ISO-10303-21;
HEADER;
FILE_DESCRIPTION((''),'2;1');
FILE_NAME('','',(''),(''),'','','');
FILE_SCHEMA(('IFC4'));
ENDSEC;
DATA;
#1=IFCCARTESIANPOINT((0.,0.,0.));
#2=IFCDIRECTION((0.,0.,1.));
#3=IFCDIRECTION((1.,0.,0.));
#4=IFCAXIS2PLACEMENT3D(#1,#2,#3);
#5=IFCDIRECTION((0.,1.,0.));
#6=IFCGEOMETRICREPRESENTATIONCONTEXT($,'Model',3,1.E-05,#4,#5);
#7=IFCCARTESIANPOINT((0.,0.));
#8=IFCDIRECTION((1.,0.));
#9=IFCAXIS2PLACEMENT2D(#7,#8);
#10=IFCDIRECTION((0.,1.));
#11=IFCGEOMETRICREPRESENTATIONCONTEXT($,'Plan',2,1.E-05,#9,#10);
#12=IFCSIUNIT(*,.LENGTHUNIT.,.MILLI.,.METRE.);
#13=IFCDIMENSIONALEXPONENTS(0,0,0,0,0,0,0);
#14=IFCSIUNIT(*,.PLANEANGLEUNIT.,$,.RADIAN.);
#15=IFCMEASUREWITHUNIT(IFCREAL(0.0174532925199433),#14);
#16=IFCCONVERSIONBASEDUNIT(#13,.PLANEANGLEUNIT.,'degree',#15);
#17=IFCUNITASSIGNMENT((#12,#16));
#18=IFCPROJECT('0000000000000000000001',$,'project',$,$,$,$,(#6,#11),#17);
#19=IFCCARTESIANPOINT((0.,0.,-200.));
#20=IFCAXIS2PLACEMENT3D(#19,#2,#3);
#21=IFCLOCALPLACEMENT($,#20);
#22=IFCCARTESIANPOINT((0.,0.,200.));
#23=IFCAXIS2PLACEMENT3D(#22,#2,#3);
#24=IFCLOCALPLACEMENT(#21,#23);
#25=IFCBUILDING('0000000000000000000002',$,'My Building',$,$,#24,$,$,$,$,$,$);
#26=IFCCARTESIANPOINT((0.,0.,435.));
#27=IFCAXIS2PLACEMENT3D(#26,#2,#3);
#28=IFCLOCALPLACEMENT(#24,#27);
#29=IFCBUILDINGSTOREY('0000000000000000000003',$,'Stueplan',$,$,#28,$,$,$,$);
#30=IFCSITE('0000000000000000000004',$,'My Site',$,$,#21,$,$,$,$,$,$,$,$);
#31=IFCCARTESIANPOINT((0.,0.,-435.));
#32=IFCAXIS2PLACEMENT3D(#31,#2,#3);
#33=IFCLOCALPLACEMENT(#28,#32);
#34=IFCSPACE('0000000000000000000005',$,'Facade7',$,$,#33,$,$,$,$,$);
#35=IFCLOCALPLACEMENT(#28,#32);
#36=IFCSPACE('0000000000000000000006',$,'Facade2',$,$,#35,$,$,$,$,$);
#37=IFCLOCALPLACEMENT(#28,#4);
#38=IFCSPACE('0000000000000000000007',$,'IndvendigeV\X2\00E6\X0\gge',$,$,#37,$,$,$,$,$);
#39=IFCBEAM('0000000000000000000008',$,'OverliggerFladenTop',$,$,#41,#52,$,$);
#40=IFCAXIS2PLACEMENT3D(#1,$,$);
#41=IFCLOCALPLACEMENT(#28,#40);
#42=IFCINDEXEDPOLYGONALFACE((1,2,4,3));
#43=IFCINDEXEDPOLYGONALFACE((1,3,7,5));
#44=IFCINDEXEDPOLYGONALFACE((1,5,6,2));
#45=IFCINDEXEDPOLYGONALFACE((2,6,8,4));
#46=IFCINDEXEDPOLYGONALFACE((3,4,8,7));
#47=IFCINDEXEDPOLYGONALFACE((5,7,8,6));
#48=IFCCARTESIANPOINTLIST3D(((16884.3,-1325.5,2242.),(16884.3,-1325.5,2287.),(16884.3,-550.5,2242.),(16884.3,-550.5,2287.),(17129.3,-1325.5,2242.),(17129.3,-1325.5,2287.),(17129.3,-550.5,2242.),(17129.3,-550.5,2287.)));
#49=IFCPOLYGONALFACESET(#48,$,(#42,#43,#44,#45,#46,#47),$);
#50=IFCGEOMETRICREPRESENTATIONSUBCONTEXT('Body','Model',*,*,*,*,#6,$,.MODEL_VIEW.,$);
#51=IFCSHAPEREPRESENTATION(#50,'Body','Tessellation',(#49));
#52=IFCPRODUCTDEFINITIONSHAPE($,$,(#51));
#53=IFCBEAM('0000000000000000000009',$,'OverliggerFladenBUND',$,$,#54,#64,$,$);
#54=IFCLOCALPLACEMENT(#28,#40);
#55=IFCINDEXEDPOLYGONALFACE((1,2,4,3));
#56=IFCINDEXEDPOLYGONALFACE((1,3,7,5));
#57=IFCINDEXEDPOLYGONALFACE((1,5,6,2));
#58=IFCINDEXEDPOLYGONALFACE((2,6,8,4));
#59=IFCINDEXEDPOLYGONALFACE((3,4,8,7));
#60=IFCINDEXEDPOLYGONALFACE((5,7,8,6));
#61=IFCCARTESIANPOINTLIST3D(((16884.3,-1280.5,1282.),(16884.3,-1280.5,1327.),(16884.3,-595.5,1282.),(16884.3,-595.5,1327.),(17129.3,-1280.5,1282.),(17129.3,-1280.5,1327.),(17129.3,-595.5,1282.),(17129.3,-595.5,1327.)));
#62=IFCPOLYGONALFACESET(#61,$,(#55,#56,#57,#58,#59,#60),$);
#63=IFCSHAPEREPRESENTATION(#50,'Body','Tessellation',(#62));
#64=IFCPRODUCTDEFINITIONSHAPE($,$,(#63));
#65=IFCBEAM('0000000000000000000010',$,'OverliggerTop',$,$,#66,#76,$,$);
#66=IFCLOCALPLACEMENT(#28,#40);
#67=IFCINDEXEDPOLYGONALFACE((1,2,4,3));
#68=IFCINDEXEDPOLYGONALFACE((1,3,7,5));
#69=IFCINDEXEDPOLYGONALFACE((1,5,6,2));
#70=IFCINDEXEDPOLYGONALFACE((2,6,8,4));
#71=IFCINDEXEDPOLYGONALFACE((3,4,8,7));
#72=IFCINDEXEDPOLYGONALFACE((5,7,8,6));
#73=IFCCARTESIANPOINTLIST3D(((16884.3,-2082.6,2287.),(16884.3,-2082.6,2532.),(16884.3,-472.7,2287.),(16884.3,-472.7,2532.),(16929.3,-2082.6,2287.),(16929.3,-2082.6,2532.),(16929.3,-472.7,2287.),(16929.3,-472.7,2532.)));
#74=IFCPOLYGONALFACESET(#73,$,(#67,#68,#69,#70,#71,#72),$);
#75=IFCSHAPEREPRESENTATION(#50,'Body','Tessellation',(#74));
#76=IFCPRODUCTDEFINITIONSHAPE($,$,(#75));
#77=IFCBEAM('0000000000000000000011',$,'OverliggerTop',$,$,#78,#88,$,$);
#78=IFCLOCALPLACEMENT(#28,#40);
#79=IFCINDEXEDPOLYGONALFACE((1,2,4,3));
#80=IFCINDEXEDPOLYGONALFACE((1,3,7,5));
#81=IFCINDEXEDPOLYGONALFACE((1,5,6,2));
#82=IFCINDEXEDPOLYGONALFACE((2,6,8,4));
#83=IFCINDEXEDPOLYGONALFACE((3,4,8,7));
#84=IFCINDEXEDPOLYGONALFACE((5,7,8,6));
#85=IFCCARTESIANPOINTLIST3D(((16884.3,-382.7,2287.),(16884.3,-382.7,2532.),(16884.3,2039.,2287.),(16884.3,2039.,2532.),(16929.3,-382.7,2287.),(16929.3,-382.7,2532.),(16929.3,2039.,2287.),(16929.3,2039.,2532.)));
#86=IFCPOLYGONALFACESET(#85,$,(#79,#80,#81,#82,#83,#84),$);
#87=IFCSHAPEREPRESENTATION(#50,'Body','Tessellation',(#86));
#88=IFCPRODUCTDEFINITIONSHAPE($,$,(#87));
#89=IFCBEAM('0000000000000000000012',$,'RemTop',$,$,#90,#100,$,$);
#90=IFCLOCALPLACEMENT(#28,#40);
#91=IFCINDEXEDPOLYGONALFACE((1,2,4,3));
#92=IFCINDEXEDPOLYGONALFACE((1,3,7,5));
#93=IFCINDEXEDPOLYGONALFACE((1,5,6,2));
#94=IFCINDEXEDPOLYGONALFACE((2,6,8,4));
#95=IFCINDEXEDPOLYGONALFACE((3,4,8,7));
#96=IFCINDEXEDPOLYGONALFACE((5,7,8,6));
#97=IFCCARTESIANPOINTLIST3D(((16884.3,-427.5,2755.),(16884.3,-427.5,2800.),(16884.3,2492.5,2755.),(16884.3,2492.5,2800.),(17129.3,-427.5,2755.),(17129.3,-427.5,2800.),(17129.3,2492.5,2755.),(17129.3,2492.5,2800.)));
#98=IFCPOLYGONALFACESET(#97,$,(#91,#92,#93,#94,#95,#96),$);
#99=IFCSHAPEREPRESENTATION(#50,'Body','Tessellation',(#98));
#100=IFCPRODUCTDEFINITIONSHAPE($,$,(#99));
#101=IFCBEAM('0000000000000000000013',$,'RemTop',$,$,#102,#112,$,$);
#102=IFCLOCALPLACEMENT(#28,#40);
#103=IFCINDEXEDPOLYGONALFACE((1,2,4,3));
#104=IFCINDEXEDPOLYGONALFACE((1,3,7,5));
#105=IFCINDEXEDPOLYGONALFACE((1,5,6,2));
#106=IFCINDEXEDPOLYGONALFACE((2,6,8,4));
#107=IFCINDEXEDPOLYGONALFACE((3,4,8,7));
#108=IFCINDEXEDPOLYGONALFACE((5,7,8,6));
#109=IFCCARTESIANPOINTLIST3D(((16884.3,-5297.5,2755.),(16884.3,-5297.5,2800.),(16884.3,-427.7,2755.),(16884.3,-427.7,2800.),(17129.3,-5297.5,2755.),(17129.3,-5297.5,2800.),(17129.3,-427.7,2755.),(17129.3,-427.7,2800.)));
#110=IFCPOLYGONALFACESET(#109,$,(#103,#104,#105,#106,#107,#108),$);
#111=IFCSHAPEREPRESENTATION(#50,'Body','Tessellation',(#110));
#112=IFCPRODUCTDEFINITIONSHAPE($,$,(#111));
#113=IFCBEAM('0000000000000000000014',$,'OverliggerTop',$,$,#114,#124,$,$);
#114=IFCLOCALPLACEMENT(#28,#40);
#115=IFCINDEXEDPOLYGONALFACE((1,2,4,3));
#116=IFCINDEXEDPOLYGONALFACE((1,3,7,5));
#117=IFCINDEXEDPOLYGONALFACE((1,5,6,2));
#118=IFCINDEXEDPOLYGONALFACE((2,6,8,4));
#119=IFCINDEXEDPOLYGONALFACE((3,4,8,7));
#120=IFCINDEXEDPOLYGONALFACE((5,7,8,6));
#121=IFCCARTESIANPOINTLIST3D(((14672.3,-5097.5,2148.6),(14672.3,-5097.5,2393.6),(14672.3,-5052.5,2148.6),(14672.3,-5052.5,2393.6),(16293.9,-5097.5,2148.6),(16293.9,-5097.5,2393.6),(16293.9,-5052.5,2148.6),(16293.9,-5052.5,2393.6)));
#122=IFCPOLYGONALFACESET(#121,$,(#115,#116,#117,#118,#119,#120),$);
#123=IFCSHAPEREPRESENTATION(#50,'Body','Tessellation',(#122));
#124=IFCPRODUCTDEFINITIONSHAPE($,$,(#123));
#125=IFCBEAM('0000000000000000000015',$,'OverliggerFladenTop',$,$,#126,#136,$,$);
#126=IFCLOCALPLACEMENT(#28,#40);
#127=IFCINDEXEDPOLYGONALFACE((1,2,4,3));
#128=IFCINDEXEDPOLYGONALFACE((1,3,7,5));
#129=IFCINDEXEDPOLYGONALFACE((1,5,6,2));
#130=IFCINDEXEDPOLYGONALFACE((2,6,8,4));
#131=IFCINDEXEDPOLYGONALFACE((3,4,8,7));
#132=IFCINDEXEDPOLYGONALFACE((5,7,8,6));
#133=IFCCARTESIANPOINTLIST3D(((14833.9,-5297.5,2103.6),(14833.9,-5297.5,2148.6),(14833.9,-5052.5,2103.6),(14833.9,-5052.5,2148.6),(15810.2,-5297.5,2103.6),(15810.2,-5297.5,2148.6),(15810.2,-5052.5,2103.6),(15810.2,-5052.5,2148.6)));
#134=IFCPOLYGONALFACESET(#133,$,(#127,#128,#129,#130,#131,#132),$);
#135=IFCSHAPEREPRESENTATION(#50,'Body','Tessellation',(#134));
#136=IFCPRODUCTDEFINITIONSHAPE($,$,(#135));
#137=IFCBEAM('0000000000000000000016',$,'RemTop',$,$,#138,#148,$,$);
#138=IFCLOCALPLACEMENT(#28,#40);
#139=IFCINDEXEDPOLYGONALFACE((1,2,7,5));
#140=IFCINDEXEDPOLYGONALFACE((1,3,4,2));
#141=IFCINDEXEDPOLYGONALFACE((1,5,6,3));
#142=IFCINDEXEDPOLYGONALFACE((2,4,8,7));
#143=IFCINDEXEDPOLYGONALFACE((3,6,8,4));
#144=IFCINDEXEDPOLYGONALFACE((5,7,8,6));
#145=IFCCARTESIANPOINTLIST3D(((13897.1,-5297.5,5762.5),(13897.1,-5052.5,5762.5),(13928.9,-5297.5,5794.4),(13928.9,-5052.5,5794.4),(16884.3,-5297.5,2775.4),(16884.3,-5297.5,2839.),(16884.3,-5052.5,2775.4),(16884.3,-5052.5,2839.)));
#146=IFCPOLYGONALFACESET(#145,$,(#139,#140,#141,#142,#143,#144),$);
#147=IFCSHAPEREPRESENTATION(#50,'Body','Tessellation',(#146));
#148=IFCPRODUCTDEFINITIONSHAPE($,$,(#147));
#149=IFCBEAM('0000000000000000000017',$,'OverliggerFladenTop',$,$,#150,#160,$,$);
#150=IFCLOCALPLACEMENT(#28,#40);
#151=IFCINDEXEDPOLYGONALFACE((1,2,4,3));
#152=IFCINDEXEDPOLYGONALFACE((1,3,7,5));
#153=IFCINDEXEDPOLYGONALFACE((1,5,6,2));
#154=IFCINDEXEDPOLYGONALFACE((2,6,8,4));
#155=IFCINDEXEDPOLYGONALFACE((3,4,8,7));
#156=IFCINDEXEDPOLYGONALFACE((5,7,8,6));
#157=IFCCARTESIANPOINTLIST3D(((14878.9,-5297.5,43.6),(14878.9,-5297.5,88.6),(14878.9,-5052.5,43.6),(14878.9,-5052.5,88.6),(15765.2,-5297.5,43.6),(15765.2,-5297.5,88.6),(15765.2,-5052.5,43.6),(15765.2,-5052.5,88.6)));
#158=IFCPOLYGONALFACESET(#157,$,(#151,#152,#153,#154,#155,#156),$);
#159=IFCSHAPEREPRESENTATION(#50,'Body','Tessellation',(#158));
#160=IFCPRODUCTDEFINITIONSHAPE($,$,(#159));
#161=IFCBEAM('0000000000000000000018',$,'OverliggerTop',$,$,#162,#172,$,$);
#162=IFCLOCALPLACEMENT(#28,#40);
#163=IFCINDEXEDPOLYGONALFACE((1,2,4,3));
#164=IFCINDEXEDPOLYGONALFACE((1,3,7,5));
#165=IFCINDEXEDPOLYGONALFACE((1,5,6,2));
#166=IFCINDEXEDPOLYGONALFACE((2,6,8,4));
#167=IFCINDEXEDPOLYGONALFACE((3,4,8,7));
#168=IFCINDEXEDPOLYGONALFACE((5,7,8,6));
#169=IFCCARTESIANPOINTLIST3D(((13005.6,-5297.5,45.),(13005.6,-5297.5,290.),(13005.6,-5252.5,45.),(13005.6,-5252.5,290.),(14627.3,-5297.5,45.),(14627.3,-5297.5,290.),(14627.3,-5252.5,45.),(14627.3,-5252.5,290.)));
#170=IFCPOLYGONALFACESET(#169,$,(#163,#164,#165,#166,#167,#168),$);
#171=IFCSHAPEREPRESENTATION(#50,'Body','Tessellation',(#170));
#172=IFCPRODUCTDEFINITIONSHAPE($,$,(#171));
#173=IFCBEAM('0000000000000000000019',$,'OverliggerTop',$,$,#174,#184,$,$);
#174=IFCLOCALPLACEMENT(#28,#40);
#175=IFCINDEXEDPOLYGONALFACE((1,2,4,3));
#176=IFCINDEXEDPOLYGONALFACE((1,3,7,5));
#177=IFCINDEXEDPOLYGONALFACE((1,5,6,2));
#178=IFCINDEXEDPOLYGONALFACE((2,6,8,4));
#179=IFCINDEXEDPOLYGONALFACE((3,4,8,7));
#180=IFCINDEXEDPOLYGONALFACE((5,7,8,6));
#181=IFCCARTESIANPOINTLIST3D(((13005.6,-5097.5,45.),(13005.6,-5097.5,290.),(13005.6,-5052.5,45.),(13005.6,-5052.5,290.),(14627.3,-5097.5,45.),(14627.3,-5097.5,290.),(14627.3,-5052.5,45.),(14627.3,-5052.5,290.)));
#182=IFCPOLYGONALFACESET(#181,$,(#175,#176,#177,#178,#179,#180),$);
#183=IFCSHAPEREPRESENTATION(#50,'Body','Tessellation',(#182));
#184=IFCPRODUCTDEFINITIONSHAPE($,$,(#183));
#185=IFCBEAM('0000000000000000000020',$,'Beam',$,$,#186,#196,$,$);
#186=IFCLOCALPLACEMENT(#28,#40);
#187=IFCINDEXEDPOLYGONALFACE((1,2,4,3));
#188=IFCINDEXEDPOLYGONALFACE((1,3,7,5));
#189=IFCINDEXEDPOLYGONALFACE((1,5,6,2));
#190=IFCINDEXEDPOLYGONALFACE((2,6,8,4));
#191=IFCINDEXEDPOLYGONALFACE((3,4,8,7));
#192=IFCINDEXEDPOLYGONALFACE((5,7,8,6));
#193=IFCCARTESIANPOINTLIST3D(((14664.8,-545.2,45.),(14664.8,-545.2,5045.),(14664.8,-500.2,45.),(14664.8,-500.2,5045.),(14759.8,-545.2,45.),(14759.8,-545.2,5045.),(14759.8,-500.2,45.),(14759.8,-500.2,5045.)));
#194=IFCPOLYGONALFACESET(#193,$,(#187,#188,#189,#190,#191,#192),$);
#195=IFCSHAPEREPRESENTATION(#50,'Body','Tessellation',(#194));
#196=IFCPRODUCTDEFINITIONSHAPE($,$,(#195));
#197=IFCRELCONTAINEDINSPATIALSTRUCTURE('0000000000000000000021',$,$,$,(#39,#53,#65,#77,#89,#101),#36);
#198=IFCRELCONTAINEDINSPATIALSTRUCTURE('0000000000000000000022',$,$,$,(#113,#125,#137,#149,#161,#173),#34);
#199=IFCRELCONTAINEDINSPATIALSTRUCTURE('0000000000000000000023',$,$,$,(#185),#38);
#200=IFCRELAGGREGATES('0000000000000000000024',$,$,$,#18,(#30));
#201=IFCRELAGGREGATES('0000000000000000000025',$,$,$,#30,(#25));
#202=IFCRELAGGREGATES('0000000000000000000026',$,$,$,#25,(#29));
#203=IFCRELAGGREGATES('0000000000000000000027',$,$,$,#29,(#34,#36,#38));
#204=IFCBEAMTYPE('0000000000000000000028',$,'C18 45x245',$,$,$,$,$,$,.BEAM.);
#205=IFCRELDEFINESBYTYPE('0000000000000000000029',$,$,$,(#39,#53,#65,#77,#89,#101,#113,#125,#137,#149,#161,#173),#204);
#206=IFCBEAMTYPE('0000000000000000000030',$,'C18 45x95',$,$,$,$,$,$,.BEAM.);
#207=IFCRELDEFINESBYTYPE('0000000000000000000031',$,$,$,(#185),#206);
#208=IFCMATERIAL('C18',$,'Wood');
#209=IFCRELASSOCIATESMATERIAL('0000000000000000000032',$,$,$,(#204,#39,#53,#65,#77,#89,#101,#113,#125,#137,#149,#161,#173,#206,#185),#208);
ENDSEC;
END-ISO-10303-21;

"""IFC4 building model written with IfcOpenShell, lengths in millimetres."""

from ifc_helpers import new_model, entity, si_unit, converted_unit, direction, frame, origin_with_axes, origin_2d_with_axis, place, context, subcontext, project, spatial, rectangle, extrude, clip, halfspace, material, material_profile, profile_set, profile_usage, type_object, element, save


model = new_model("IFC4")

# Units and contexts
model_context = context("Model", 3, precision=1e-05, world=origin_with_axes(), true_north=direction((0.0, 1.0, 0.0)))
plan_context = context("Plan", 2, precision=1e-05, world=origin_2d_with_axis(), true_north=direction((0.0, 1.0)))
body_context_1 = subcontext(model_context, "Body", "Model", "MODEL_VIEW")
ifc_project = project(units=[si_unit("LENGTHUNIT", "METRE", prefix="MILLI"), converted_unit("PLANEANGLEUNIT", "degree", entity("IfcReal", 0.0174532925199433), si_unit("PLANEANGLEUNIT", "RADIAN"), dimensions=[0, 0, 0, 0, 0, 0, 0])], contexts=[model_context, plan_context])

# Site, building, storey, space
site_placement = place(None, frame((0.0, 0.0, -200.0), z_axis=(0.0, 0.0, 1.0), x_axis=(1.0, 0.0, 0.0)))
site = spatial("IfcSite", under=ifc_project, at=site_placement, Name="My Site")
building_placement = place(site_placement, frame((0.0, 0.0, 200.0), z_axis=(0.0, 0.0, 1.0), x_axis=(1.0, 0.0, 0.0)))
building = spatial("IfcBuilding", under=site, at=building_placement, Name="My Building")
storey_placement = place(building_placement, frame((0.0, 0.0, 435.0), z_axis=(0.0, 0.0, 1.0), x_axis=(1.0, 0.0, 0.0)))
storey = spatial("IfcBuildingStorey", under=building, at=storey_placement, Name="Stueplan")
space_1_placement = place(storey_placement, frame((0.0, 0.0, -435.0), z_axis=(0.0, 0.0, 1.0), x_axis=(1.0, 0.0, 0.0)))
space_1 = spatial("IfcSpace", under=storey, at=space_1_placement, Name="Facade7")

# Shared definitions
ifc_material = material(Name="C18", Category="Wood")

# Shared definitions
space_2_placement = place(storey_placement, frame((0.0, 0.0, -435.0), z_axis=(0.0, 0.0, 1.0), x_axis=(1.0, 0.0, 0.0)))
space_2 = spatial("IfcSpace", under=storey, at=space_2_placement, Name="Facade2")

# Beams
ifc_material_profile_1 = material_profile(ifc_material, rectangle(XDim=45.0, YDim=245.0), Name="concrete")
ifc_profile_set_1 = profile_set([ifc_material_profile_1], Name="woodStructural")
ifc_profile_usage_1 = profile_usage(ifc_profile_set_1)
beam_type_1 = type_object("IfcBeamType", Name="C18 45x245", PredefinedType="BEAM", material=ifc_profile_set_1)
beam_1_placement = place(space_2_placement, frame((17006.8, -1325.5, 2699.5), z_axis=(0.0, 1.0, 0.0), x_axis=(0.0, 0.0, 1.0)))
element("IfcBeam", 1, at=beam_1_placement, inside=space_2, type_object=beam_type_1, material=ifc_profile_usage_1, Name="OverliggerFladenTop", context=body_context_1, shape_type="SweptSolid", body=[
    extrude(rectangle(XDim=45.0, YDim=245.0), origin_with_axes(), (0.0, 0.0, 1.0), 775.0),
])
ifc_profile_usage_2 = profile_usage(ifc_profile_set_1)
beam_2_placement = place(space_2_placement, frame((17006.8, -1280.5, 1739.5), z_axis=(0.0, 1.0, 0.0), x_axis=(0.0, 0.0, 1.0)))
element("IfcBeam", 2, at=beam_2_placement, inside=space_2, type_object=beam_type_1, material=ifc_profile_usage_2, Name="OverliggerFladenBUND", context=body_context_1, shape_type="SweptSolid", body=[
    extrude(rectangle(XDim=45.0, YDim=245.0), origin_with_axes(), (0.0, 0.0, 1.0), 685.0),
])
ifc_profile_usage_3 = profile_usage(ifc_profile_set_1)
beam_3_placement = place(space_2_placement, frame((16906.8, -2082.6, 2844.5), z_axis=(0.0, 1.0, 0.0), x_axis=(1.0, 0.0, 0.0)))
element("IfcBeam", 3, at=beam_3_placement, inside=space_2, type_object=beam_type_1, material=ifc_profile_usage_3, Name="OverliggerTop", context=body_context_1, shape_type="SweptSolid", body=[
    extrude(rectangle(XDim=45.0, YDim=245.0), origin_with_axes(), (0.0, 0.0, 1.0), 1609.9),
])
ifc_profile_usage_4 = profile_usage(ifc_profile_set_1)
beam_4_placement = place(space_2_placement, frame((16906.8, -382.7, 2844.5), z_axis=(0.0, 1.0, 0.0), x_axis=(1.0, 0.0, 0.0)))
element("IfcBeam", 4, at=beam_4_placement, inside=space_2, type_object=beam_type_1, material=ifc_profile_usage_4, Name="OverliggerTop", context=body_context_1, shape_type="SweptSolid", body=[
    extrude(rectangle(XDim=45.0, YDim=245.0), origin_with_axes(), (0.0, 0.0, 1.0), 2421.7),
])
ifc_profile_usage_5 = profile_usage(ifc_profile_set_1)
beam_5_placement = place(space_2_placement, frame((17006.8, -427.5, 3212.5), z_axis=(0.0, 1.0, 0.0), x_axis=(0.0, 0.0, 1.0)))
element("IfcBeam", 5, at=beam_5_placement, inside=space_2, type_object=beam_type_1, material=ifc_profile_usage_5, Name="RemTop", context=body_context_1, shape_type="SweptSolid", body=[
    extrude(rectangle(XDim=45.0, YDim=245.0), origin_with_axes(), (0.0, 0.0, 1.0), 2920.0),
])
ifc_profile_usage_6 = profile_usage(ifc_profile_set_1)
beam_6_placement = place(space_2_placement, frame((17006.8, -5297.5, 3212.5), z_axis=(0.0, 1.0, 0.0), x_axis=(0.0, 0.0, 1.0)))
element("IfcBeam", 6, at=beam_6_placement, inside=space_2, type_object=beam_type_1, material=ifc_profile_usage_6, Name="RemTop", context=body_context_1, shape_type="SweptSolid", body=[
    extrude(rectangle(XDim=45.0, YDim=245.0), origin_with_axes(), (0.0, 0.0, 1.0), 4869.8),
])
ifc_profile_usage_7 = profile_usage(ifc_profile_set_1)
beam_7_placement = place(space_1_placement, frame((14672.3, -5075.0, 2706.1), z_axis=(1.0, 0.0, 0.0), x_axis=(0.0, -1.0, 0.0)))
element("IfcBeam", 7, at=beam_7_placement, inside=space_1, type_object=beam_type_1, material=ifc_profile_usage_7, Name="OverliggerTop", context=body_context_1, shape_type="SweptSolid", body=[
    extrude(rectangle(XDim=45.0, YDim=245.0), origin_with_axes(), (0.0, 0.0, 1.0), 1621.7),
])
ifc_profile_usage_8 = profile_usage(ifc_profile_set_1)
beam_8_placement = place(space_1_placement, frame((14833.9, -5175.0, 2561.1), z_axis=(1.0, 0.0, 0.0), x_axis=(0.0, 0.0, 1.0)))
element("IfcBeam", 8, at=beam_8_placement, inside=space_1, type_object=beam_type_1, material=ifc_profile_usage_8, Name="OverliggerFladenTop", context=body_context_1, shape_type="SweptSolid", body=[
    extrude(rectangle(XDim=45.0, YDim=245.0), origin_with_axes(), (0.0, 0.0, 1.0), 976.4),
])
ifc_profile_usage_9 = profile_usage(ifc_profile_set_1)
beam_9_placement = place(space_1_placement, frame((13913.0, -5175.0, 6213.4), z_axis=(0.707107, 0.0, -0.707107), x_axis=(0.707107, 0.000001, 0.707107)))
element("IfcBeam", 9, at=beam_9_placement, inside=space_1, type_object=beam_type_1, material=ifc_profile_usage_9, Name="RemTop", context=body_context_1, shape_type="Clipping", body=[
    clip(extrude(rectangle(XDim=45.0, YDim=245.0), origin_with_axes(), (0.0, 0.0, 1.0), 4447.0), halfspace(frame((-1953.2, 122.5, 6155.1), z_axis=(0.707107, 0.000001, 0.707107), x_axis=(0.000001, -1.0, 0.0)), False)),
])
ifc_profile_usage_10 = profile_usage(ifc_profile_set_1)
beam_10_placement = place(space_1_placement, frame((14878.9, -5175.0, 501.1), z_axis=(1.0, 0.0, 0.0), x_axis=(0.0, 0.0, 1.0)))
element("IfcBeam", 10, at=beam_10_placement, inside=space_1, type_object=beam_type_1, material=ifc_profile_usage_10, Name="OverliggerFladenTop", context=body_context_1, shape_type="SweptSolid", body=[
    extrude(rectangle(XDim=45.0, YDim=245.0), origin_with_axes(), (0.0, 0.0, 1.0), 886.4),
])
ifc_profile_usage_11 = profile_usage(ifc_profile_set_1)
beam_11_placement = place(space_1_placement, frame((13005.6, -5275.0, 602.5), z_axis=(1.0, 0.0, 0.0), x_axis=(0.0, -1.0, 0.0)))
element("IfcBeam", 11, at=beam_11_placement, inside=space_1, type_object=beam_type_1, material=ifc_profile_usage_11, Name="OverliggerTop", context=body_context_1, shape_type="SweptSolid", body=[
    extrude(rectangle(XDim=45.0, YDim=245.0), origin_with_axes(), (0.0, 0.0, 1.0), 1621.7),
])
ifc_profile_usage_12 = profile_usage(ifc_profile_set_1)
beam_12_placement = place(space_1_placement, frame((13005.6, -5075.0, 602.5), z_axis=(1.0, 0.0, 0.0), x_axis=(0.0, -1.0, 0.0)))
element("IfcBeam", 12, at=beam_12_placement, inside=space_1, type_object=beam_type_1, material=ifc_profile_usage_12, Name="OverliggerTop", context=body_context_1, shape_type="SweptSolid", body=[
    extrude(rectangle(XDim=45.0, YDim=245.0), origin_with_axes(), (0.0, 0.0, 1.0), 1621.7),
])

# Shared definitions
space_3_placement = place(storey_placement, frame((0.0, 0.0, 0.0), z_axis=(0.0, 0.0, 1.0), x_axis=(1.0, 0.0, 0.0)))
space_3 = spatial("IfcSpace", under=storey, at=space_3_placement, Name="IndvendigeVægge")

# Beam
ifc_material_profile_2 = material_profile(ifc_material, rectangle(XDim=45.0, YDim=95.0))
ifc_profile_set_2 = profile_set([ifc_material_profile_2], Name="woodStructural")
ifc_profile_usage_13 = profile_usage(ifc_profile_set_2)
beam_type_2 = type_object("IfcBeamType", Name="C18 45x95", PredefinedType="BEAM", material=ifc_profile_set_2)
beam_13_placement = place(space_3_placement, frame((14712.3, -522.7, 45.0), z_axis=(0.0, 0.0, 1.0), x_axis=(0.0, 1.0, 0.0)))
element("IfcBeam", 13, at=beam_13_placement, inside=space_3, type_object=beam_type_2, material=ifc_profile_usage_13, Name="Beam", context=body_context_1, shape_type="SweptSolid", body=[
    extrude(rectangle(XDim=45.0, YDim=95.0), origin_with_axes(), (0.0, 0.0, 1.0), 5000.0),
])

save(model, "model.ifc")
